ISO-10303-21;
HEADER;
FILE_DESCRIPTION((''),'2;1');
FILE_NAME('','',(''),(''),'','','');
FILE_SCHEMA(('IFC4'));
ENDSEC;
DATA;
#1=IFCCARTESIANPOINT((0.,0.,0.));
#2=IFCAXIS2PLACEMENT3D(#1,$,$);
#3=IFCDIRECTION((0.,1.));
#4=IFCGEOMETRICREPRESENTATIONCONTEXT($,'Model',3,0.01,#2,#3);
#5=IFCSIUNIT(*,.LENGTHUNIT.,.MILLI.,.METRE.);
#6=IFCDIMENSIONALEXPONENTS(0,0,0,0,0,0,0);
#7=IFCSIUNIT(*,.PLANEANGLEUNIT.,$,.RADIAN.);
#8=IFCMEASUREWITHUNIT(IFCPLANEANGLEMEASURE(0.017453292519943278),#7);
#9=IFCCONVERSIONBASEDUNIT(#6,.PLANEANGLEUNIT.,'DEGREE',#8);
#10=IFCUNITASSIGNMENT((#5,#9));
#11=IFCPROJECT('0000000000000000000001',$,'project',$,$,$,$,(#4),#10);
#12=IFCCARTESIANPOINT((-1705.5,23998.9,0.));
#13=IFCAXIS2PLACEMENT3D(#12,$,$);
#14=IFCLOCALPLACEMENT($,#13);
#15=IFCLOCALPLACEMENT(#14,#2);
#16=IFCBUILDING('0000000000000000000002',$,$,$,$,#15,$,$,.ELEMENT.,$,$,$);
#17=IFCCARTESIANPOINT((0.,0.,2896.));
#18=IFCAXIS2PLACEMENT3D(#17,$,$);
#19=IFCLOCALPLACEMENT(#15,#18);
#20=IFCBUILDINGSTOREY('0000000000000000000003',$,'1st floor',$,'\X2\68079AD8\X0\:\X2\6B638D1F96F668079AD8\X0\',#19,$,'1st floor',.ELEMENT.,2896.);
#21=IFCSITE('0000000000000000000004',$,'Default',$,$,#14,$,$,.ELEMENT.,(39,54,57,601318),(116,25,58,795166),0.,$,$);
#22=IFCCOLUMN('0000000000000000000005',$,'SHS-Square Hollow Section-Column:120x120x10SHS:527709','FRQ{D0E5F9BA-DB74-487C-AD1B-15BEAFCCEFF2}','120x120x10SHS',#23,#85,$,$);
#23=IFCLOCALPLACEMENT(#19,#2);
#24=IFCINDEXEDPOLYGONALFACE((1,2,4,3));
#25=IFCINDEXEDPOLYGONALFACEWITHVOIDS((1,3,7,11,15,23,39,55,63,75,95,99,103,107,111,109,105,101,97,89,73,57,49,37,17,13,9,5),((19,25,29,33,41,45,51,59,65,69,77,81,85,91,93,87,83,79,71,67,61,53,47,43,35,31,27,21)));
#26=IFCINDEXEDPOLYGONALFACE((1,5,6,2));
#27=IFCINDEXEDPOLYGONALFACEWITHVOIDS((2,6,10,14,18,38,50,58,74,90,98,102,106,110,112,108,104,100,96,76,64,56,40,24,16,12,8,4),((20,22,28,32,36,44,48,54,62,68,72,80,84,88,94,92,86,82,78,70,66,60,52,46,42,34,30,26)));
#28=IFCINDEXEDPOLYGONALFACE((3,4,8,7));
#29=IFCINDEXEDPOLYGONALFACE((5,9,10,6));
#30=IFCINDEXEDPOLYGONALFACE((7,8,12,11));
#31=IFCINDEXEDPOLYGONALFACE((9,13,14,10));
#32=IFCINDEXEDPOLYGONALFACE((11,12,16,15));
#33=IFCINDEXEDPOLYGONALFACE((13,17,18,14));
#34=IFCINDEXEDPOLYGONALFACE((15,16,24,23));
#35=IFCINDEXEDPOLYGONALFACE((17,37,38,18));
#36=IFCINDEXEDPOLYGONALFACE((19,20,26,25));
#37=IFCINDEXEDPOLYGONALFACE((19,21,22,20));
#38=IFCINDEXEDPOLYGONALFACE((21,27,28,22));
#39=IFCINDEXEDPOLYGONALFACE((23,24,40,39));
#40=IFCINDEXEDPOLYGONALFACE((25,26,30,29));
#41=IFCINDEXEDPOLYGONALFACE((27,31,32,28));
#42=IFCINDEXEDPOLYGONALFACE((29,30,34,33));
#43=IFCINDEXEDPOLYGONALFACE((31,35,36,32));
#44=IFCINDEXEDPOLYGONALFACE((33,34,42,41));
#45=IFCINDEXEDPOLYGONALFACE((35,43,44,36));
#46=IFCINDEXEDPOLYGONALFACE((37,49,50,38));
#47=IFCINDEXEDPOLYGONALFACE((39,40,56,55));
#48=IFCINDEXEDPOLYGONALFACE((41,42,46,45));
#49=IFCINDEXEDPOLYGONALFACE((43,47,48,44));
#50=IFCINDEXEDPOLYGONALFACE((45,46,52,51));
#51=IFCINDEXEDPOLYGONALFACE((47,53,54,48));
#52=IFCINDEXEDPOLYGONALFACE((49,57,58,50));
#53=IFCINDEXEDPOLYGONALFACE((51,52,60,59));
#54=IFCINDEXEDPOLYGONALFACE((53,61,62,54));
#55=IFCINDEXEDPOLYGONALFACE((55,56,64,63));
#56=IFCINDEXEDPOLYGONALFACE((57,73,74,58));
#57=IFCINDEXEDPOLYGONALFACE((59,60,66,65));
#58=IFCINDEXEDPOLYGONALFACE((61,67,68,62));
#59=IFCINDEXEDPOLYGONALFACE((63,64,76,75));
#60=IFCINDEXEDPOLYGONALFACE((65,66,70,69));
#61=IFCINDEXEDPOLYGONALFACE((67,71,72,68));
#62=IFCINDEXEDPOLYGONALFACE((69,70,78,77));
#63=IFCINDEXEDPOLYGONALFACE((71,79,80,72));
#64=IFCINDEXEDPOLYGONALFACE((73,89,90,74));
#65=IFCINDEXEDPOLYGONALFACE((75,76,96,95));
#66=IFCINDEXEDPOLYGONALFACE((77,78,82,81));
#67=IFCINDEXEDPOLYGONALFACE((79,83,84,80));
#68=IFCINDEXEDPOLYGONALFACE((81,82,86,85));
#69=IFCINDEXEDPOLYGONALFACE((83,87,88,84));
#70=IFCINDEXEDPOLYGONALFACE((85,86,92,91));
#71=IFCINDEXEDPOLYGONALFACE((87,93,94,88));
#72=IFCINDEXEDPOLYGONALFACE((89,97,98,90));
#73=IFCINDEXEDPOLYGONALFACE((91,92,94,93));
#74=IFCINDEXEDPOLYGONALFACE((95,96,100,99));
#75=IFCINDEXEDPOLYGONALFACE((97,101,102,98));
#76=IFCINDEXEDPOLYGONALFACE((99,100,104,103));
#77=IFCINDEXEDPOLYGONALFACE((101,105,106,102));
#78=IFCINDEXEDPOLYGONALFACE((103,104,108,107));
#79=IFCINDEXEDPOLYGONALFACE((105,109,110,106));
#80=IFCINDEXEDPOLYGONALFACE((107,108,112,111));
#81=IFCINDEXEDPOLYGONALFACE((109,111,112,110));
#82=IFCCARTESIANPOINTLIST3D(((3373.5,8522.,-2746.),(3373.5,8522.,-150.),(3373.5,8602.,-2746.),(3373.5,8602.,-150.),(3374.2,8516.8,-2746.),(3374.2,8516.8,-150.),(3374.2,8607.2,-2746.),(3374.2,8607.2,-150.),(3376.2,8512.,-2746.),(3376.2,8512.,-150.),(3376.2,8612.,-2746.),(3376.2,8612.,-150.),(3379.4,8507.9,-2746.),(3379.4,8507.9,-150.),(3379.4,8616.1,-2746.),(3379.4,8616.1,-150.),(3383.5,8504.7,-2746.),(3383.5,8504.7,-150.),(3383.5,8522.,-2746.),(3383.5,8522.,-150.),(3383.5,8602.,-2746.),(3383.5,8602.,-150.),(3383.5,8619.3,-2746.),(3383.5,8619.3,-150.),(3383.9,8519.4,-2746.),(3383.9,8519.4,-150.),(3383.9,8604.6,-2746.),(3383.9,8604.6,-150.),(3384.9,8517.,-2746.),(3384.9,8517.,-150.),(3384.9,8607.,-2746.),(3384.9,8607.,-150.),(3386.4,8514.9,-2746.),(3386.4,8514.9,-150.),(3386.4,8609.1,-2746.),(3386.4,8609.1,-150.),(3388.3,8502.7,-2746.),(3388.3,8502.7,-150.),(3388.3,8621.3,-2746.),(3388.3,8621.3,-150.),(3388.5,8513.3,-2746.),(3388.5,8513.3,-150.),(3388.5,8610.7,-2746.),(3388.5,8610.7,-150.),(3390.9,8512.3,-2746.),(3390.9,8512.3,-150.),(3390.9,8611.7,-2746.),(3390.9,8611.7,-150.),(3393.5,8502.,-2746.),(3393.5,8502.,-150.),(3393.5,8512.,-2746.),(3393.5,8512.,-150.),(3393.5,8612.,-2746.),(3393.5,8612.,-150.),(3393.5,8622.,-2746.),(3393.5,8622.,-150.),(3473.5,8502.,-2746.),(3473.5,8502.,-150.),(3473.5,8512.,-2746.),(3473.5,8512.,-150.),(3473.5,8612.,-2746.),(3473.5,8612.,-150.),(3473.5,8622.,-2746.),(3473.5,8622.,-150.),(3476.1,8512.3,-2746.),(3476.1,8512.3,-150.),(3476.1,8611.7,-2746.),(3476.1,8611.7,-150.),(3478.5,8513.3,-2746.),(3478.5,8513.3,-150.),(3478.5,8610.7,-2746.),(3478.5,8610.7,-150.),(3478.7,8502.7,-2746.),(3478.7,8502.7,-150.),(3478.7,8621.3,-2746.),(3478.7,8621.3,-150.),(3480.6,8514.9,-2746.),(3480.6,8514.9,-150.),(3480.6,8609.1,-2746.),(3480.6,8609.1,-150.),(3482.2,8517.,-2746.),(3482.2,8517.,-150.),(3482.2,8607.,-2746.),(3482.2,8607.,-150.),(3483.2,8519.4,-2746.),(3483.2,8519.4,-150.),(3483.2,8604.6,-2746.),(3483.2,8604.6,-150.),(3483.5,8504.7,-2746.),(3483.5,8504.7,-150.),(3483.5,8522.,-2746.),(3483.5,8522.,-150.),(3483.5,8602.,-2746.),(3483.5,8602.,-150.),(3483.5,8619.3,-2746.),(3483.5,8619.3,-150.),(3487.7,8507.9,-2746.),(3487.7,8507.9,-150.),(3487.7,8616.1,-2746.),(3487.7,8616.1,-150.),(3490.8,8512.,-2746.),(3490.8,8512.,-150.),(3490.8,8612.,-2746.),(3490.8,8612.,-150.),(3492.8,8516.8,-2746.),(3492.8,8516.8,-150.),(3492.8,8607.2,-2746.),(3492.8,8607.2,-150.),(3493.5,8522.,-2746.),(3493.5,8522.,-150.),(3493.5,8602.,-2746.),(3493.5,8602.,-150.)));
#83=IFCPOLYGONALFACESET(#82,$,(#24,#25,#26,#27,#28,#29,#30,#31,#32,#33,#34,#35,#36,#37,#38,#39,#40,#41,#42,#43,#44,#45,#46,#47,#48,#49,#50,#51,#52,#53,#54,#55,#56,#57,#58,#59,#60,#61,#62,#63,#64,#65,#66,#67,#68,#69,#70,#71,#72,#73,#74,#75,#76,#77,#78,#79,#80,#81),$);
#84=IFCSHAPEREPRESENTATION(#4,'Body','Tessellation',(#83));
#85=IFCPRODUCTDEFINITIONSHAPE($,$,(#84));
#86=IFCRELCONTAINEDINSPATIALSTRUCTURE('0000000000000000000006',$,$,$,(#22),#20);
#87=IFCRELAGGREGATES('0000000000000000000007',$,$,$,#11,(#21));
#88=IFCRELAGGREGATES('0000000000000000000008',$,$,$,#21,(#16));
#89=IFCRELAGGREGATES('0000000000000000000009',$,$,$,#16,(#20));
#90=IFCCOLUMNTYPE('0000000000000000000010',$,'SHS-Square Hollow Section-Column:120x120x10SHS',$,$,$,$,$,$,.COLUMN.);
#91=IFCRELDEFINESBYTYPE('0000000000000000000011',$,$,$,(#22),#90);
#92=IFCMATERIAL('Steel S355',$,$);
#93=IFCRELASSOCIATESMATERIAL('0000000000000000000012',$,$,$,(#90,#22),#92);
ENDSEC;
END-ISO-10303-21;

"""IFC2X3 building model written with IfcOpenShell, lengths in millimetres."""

from ifc_helpers import new_model, entity, si_unit, converted_unit, direction, frame, origin, origin_2d, place, context, project, spatial, hollow_rectangle, extrude, clip, halfspace, material, type_object, element, save


model = new_model("IFC2X3")

# Units and contexts
model_context = context("Model", 3, precision=0.01, world=origin(), true_north=direction((0.0, 1.0)))
ifc_project = project(units=[si_unit("LENGTHUNIT", "METRE", prefix="MILLI"), converted_unit("PLANEANGLEUNIT", "DEGREE", entity("IfcPlaneAngleMeasure", 0.017453292519943278), si_unit("PLANEANGLEUNIT", "RADIAN"), dimensions=[0, 0, 0, 0, 0, 0, 0])], contexts=[model_context])

# Site, building, storey
site_placement = place(None, frame((-1705.5, 23998.9, 0.0)))
site = spatial("IfcSite", under=ifc_project, at=site_placement, Name="Default", CompositionType="ELEMENT", RefLatitude=(39, 54, 57, 601318), RefLongitude=(116, 25, 58, 795166), RefElevation=0.0)
building_placement = place(site_placement, origin())
building = spatial("IfcBuilding", under=site, at=building_placement, CompositionType="ELEMENT")
storey_placement = place(building_placement, frame((0.0, 0.0, 2896.0)))
storey = spatial("IfcBuildingStorey", under=building, at=storey_placement, Name="1st floor", ObjectType="标高:正负零标高", LongName="1st floor", CompositionType="ELEMENT", Elevation=2896.0)

# Shared definitions
ifc_material_1 = material(Name="Steel S355")

# Column
column_type_1 = type_object("IfcColumnType", Name="SHS-Square Hollow Section-Column:120x120x10SHS", PredefinedType="COLUMN", material=ifc_material_1)
column_1_placement = place(storey_placement, frame((3433.5, 8562.0, -65.1), z_axis=(0.0, 0.0, 1.0), x_axis=(0.0, -1.0, 0.0)))
element("IfcColumn", 1, at=column_1_placement, inside=storey, type_object=column_type_1, material=ifc_material_1, Name="SHS-Square Hollow Section-Column:120x120x10SHS:527709", Description="FRQ{D0E5F9BA-DB74-487C-AD1B-15BEAFCCEFF2}", ObjectType="120x120x10SHS", context=model_context, shape_type="Clipping", body=[
    clip(clip(extrude(hollow_rectangle(XDim=120.0, YDim=120.0, WallThickness=10.0, InnerFilletRadius=10.0, OuterFilletRadius=20.0, at=origin_2d()), origin(), (0.0, 0.0, -1.0), 2765.7), halfspace(frame((8562.0, -3433.5, -2680.9), z_axis=(0.0, 0.0, 1.0), x_axis=(0.0, 1.0, 0.0)), True)), halfspace(frame((8562.0, -3433.5, -84.9), z_axis=(0.0, 0.0, -1.0), x_axis=(0.0, -1.0, 0.0)), True)),
])

save(model, "model.ifc")
